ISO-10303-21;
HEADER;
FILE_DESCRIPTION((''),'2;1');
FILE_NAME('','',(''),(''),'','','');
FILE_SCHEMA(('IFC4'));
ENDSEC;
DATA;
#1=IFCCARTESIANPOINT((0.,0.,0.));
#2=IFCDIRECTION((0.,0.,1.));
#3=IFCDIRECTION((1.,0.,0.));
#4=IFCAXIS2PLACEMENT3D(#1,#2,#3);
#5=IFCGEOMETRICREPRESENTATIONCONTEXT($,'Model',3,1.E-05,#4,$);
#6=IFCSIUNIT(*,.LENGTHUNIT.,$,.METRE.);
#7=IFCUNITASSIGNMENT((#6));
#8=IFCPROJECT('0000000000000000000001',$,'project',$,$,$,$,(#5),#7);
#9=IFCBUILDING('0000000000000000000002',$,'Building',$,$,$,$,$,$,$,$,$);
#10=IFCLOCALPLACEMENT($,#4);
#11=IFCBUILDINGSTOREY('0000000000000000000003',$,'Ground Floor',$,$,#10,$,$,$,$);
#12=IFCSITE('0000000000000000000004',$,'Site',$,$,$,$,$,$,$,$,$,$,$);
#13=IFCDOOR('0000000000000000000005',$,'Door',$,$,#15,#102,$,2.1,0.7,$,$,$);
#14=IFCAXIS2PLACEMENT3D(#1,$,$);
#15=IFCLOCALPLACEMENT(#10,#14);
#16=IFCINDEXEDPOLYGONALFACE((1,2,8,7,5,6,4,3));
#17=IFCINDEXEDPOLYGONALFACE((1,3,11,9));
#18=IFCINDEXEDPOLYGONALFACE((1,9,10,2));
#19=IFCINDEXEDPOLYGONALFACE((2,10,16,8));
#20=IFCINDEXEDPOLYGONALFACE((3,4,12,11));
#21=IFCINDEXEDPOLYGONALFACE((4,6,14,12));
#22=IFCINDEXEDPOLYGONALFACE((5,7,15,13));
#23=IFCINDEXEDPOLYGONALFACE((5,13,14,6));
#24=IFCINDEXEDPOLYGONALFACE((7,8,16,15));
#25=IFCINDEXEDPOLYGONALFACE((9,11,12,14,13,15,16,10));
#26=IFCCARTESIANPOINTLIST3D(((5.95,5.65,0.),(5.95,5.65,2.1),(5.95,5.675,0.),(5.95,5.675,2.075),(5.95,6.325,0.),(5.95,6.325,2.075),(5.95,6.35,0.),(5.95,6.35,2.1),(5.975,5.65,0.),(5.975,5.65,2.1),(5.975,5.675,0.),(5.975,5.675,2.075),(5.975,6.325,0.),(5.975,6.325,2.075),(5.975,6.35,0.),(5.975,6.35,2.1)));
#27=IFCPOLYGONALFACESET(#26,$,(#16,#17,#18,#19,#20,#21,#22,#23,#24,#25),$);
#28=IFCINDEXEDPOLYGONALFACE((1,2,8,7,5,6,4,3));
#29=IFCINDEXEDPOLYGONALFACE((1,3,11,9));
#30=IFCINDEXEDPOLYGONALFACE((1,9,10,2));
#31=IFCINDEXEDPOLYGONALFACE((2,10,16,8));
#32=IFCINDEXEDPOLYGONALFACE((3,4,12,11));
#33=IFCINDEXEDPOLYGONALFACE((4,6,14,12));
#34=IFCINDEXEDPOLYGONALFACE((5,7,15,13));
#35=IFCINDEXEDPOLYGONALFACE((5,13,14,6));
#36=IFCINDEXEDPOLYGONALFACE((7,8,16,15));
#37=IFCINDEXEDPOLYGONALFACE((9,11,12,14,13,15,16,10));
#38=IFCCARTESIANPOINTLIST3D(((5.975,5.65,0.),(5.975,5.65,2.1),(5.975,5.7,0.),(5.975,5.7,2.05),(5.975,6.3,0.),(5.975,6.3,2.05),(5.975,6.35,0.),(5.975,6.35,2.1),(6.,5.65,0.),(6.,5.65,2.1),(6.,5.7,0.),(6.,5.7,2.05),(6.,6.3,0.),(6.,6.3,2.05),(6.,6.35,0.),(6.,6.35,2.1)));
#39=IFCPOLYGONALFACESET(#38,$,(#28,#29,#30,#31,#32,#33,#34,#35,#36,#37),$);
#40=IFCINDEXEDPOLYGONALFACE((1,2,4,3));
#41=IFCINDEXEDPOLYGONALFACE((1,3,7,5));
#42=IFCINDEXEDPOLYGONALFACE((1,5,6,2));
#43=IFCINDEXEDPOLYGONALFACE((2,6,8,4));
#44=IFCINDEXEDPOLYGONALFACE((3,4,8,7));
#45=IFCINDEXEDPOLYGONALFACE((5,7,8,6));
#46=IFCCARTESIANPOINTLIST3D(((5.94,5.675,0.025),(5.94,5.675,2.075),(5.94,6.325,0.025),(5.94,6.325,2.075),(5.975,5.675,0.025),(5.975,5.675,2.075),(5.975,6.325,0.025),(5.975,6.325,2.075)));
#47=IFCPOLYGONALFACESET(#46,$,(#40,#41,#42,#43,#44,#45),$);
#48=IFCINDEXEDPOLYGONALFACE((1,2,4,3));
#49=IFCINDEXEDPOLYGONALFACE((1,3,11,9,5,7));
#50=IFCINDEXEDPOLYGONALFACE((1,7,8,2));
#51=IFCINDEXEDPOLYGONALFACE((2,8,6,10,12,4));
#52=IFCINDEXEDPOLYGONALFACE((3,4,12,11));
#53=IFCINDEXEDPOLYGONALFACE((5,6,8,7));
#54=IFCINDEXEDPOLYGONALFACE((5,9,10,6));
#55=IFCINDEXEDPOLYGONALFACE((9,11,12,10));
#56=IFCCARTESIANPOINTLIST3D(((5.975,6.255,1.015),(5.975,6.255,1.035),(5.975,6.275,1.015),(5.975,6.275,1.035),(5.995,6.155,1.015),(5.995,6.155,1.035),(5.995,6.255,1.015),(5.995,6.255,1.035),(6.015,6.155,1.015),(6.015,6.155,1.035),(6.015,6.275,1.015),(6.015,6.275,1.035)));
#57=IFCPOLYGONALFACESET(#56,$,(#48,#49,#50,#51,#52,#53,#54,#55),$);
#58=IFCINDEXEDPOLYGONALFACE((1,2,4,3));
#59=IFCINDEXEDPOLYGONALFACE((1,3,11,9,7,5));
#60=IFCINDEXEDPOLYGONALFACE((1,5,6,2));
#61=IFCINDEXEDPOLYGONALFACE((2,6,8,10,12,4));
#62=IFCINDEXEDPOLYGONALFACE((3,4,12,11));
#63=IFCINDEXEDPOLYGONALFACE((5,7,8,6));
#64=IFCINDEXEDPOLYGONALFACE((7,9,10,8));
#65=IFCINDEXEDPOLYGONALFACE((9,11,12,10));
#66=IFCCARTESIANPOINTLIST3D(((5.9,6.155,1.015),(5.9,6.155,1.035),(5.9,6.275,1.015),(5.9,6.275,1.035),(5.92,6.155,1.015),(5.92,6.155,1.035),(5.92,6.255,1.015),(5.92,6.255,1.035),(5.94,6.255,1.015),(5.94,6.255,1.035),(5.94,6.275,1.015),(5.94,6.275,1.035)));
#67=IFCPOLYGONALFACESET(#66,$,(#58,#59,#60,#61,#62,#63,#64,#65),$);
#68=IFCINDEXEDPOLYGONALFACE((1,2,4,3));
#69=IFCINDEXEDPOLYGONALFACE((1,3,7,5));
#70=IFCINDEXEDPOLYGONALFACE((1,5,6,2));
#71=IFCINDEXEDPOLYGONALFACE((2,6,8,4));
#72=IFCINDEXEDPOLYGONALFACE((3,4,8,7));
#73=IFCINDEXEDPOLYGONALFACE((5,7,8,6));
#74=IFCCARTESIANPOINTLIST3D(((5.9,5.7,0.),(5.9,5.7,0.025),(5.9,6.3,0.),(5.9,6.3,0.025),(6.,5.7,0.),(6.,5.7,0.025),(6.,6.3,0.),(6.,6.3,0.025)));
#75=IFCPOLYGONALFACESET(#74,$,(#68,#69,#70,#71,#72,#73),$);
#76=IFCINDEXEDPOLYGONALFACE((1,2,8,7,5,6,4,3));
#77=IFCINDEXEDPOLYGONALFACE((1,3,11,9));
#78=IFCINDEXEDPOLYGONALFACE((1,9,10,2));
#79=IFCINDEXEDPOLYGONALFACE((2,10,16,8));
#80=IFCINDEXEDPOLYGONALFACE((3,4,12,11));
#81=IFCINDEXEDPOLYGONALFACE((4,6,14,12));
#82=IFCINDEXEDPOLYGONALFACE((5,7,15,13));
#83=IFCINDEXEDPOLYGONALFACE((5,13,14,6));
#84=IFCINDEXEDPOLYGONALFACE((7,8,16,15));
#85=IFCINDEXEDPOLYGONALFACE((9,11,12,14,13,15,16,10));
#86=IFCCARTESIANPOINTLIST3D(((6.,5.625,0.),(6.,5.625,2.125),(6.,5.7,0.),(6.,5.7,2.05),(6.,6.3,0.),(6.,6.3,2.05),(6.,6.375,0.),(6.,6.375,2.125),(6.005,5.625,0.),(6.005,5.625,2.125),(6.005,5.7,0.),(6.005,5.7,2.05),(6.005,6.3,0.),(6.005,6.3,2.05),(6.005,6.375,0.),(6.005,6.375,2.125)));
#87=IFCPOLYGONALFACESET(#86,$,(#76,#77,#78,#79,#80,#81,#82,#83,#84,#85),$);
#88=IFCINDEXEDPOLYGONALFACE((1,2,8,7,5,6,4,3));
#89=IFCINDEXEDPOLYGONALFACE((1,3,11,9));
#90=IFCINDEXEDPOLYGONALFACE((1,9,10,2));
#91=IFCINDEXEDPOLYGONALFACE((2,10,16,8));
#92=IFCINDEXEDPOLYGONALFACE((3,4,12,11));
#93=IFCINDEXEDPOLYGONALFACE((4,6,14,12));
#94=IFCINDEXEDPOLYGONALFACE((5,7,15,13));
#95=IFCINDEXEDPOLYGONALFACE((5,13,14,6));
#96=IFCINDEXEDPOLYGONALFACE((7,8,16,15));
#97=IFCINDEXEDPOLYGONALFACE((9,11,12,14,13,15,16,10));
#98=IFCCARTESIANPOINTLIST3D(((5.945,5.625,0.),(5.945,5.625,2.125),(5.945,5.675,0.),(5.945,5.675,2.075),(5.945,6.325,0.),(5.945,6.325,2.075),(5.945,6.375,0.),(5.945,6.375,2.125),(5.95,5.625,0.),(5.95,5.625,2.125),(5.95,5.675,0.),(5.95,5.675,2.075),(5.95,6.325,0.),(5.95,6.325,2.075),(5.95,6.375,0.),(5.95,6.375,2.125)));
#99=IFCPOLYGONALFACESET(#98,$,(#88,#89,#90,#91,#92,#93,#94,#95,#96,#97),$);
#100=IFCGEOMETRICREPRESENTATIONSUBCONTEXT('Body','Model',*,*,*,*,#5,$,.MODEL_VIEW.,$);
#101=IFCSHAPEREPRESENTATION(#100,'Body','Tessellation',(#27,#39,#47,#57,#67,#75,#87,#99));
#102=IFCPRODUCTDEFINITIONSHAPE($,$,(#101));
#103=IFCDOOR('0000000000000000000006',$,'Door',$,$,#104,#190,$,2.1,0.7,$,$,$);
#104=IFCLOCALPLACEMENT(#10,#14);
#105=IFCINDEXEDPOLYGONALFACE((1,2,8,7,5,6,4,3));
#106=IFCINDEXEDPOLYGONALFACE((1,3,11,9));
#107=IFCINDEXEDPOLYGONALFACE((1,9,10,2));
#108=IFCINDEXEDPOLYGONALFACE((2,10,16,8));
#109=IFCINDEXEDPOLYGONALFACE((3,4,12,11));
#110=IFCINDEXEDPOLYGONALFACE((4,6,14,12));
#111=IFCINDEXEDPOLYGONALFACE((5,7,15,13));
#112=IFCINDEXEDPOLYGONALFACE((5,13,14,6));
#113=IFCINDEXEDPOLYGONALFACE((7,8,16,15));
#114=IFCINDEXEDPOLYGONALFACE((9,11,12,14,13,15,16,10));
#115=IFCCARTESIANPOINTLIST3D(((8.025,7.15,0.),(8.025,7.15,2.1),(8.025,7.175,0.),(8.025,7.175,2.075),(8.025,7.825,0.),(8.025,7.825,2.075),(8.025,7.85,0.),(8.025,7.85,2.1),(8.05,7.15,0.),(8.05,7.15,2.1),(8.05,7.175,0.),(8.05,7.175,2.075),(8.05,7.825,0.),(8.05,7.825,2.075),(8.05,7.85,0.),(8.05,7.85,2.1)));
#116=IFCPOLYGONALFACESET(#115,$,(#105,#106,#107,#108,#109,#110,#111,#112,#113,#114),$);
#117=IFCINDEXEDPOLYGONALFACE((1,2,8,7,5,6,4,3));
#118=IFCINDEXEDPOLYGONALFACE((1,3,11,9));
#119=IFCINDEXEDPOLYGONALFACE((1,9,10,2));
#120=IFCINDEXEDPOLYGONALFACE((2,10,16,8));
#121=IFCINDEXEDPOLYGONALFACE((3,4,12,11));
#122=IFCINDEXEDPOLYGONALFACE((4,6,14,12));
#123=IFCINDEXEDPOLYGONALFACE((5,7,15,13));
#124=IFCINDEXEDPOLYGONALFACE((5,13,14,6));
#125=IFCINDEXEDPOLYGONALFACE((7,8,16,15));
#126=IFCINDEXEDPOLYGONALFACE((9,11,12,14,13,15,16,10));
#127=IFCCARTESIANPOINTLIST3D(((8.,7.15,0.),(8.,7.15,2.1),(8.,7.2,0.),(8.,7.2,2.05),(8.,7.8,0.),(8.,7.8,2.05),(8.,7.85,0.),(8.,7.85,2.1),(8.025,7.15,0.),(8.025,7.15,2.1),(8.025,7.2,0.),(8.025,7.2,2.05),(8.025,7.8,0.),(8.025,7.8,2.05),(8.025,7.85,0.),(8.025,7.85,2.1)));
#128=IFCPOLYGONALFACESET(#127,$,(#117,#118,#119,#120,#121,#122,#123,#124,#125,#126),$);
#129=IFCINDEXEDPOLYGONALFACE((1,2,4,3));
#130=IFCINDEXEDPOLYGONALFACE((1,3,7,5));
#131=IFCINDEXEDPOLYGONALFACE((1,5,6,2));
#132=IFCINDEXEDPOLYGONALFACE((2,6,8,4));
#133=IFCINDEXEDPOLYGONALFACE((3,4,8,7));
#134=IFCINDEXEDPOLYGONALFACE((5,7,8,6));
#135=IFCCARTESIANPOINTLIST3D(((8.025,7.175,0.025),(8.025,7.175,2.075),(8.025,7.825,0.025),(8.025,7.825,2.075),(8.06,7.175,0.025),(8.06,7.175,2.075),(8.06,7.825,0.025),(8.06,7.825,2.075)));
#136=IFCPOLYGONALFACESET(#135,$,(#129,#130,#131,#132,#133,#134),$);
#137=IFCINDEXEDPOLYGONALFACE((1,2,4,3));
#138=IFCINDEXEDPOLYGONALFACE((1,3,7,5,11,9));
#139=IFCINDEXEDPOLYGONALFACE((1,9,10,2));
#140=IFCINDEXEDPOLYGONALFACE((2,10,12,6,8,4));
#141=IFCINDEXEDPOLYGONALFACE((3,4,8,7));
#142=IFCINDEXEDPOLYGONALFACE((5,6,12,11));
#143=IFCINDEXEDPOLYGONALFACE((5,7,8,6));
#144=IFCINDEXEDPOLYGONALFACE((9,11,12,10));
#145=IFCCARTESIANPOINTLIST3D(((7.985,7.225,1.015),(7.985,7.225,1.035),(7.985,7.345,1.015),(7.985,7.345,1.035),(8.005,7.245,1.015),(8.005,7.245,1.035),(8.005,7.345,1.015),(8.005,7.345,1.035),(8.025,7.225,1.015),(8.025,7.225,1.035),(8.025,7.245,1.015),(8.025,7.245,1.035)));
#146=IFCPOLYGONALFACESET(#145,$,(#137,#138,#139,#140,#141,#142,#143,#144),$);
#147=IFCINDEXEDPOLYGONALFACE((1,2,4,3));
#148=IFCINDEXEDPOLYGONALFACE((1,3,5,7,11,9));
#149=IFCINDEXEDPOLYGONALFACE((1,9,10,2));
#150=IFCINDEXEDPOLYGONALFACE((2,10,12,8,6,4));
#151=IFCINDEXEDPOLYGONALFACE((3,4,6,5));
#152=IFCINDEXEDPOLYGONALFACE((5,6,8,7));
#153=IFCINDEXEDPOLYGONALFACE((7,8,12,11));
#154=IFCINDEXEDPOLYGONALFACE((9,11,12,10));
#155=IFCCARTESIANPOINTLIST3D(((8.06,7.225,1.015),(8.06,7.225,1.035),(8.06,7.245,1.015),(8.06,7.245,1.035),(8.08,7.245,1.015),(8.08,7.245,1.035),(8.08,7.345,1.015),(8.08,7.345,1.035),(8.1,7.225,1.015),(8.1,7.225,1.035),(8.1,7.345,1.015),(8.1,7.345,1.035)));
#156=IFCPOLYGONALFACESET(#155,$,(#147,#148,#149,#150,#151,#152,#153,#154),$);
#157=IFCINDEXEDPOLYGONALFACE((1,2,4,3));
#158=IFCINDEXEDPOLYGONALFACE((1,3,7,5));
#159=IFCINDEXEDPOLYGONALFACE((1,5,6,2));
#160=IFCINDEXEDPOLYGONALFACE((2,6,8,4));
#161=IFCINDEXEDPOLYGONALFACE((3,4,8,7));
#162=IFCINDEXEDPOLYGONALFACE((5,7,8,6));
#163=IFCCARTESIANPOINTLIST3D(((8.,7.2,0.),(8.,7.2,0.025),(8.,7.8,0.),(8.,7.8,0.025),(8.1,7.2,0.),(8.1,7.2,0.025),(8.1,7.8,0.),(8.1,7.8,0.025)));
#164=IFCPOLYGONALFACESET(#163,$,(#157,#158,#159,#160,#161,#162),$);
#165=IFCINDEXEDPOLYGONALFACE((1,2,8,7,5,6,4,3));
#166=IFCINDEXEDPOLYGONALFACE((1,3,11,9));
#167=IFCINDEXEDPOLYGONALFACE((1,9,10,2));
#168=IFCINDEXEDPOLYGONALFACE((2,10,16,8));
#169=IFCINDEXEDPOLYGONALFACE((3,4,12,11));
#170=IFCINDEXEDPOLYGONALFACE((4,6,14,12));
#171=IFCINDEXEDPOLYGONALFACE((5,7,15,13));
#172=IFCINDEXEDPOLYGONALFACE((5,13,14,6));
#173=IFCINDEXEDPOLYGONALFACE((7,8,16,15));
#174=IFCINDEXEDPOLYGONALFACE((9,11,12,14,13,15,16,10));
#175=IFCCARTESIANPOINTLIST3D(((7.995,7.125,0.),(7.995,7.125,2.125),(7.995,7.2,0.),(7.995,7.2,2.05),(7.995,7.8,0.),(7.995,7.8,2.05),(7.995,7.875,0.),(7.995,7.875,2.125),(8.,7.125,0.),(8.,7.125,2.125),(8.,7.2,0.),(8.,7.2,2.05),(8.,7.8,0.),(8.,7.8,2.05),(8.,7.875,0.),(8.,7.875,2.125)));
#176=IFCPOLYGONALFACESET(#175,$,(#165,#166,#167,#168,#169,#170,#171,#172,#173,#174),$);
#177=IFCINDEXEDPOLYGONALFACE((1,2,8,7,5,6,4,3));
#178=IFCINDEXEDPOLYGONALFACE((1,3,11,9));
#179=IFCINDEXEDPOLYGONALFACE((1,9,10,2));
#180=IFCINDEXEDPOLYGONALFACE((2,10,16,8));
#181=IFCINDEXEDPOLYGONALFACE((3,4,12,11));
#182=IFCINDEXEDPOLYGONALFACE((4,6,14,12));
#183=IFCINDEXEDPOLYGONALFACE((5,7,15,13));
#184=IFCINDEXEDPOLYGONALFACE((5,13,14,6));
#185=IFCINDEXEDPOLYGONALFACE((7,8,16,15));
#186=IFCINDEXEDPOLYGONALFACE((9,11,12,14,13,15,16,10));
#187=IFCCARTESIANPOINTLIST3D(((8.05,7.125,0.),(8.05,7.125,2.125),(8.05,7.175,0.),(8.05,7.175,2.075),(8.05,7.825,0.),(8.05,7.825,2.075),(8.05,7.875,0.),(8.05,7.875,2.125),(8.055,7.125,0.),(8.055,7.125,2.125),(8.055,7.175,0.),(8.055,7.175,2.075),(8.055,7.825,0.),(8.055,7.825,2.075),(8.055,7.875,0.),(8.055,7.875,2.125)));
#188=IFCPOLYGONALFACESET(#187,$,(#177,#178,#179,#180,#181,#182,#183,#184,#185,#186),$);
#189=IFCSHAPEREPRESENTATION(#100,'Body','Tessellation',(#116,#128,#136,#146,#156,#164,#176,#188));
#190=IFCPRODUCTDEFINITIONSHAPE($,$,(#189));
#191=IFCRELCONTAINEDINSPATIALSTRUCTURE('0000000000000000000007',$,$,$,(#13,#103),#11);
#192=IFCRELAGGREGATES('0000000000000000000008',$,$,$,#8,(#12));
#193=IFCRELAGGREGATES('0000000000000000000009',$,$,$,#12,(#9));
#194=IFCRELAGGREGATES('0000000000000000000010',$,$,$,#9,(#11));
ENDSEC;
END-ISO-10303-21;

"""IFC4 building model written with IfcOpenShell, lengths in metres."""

from ifc_helpers import new_model, si_unit, frame, origin_with_axes, place, context, subcontext, project, spatial, line, indexed_curve, outline, extrude, element, save


model = new_model("IFC4")

# Units and contexts
model_context = context("Model", 3, precision=1e-05, world=origin_with_axes())
body_context = subcontext(model_context, "Body", "Model", "MODEL_VIEW")
ifc_project = project(units=[si_unit("LENGTHUNIT", "METRE")], contexts=[model_context])

# Site, building, storey
site = spatial("IfcSite", under=ifc_project, Name="Site")
building = spatial("IfcBuilding", under=site, Name="Building")
storey_placement = place(None, origin_with_axes())
storey = spatial("IfcBuildingStorey", under=building, at=storey_placement, Name="Ground Floor")

# Doors
door_1_placement = place(storey_placement, frame((6.0, 5.65, 0.0), z_axis=(0.0, 0.0, 1.0), x_axis=(0.0, 1.0, 0.0)))
element("IfcDoor", 1, at=door_1_placement, inside=storey, Name="Door", OverallHeight=2.1, OverallWidth=0.7, context=body_context, shape_type="SweptSolid", body=[
    extrude(outline(indexed_curve([(0.0, 0.0), (0.0, 2.1), (0.7, 2.1), (0.7, 0.0), (0.675, 0.0), (0.675, 2.075), (0.025, 2.075), (0.025, 0.0)], segments=[line(1, 2, 3, 4, 5, 6, 7, 8, 1)])), frame((0.0, 0.025, 0.0), z_axis=(0.0, -1.0, 0.0), x_axis=(1.0, 0.0, 0.0)), (0.0, 0.0, -1.0), 0.025),
    extrude(outline(indexed_curve([(0.0, 0.0), (0.0, 2.1), (0.7, 2.1), (0.7, 0.0), (0.65, 0.0), (0.65, 2.05), (0.05, 2.05), (0.05, 0.0)], segments=[line(1, 2, 3, 4, 5, 6, 7, 8, 1)])), frame((0.0, 0.0, 0.0), z_axis=(0.0, -1.0, 0.0), x_axis=(1.0, 0.0, 0.0)), (0.0, 0.0, -1.0), 0.025),
    extrude(outline(indexed_curve([(0.0, 0.0), (0.65, 0.0), (0.65, 0.035), (0.0, 0.035)], segments=[line(1, 2, 3, 4, 1)])), frame((0.025, 0.025, 0.025), z_axis=(0.0, 0.0, 1.0), x_axis=(1.0, 0.0, 0.0)), (0.0, 0.0, 1.0), 2.05),
    extrude(outline(indexed_curve([(0.0, 0.0), (0.0, -0.04), (-0.12, -0.04), (-0.12, -0.02), (-0.02, -0.02), (-0.02, 0.0)], segments=[line(1, 2, 3, 4, 5, 6, 1)])), frame((0.625, 0.025, 1.015), z_axis=(0.0, 0.0, 1.0), x_axis=(1.0, 0.0, 0.0)), (0.0, 0.0, 1.0), 0.02),
    extrude(outline(indexed_curve([(0.0, 0.0), (0.0, 0.04), (-0.12, 0.04), (-0.12, 0.02), (-0.02, 0.02), (-0.02, 0.0)], segments=[line(1, 2, 3, 4, 5, 6, 1)])), frame((0.625, 0.06, 1.015), z_axis=(0.0, 0.0, 1.0), x_axis=(1.0, 0.0, 0.0)), (0.0, 0.0, 1.0), 0.02),
    extrude(outline(indexed_curve([(0.0, 0.0), (0.6, 0.0), (0.6, 0.1), (0.0, 0.1)], segments=[line(1, 2, 3, 4, 1)])), frame((0.05, 0.0, 0.0), z_axis=(0.0, 0.0, 1.0), x_axis=(1.0, 0.0, 0.0)), (0.0, 0.0, 1.0), 0.025),
    extrude(outline(indexed_curve([(0.0, 0.0), (0.0, 2.125), (0.75, 2.125), (0.75, 0.0), (0.675, 0.0), (0.675, 2.05), (0.075, 2.05), (0.075, 0.0)], segments=[line(1, 2, 3, 4, 5, 6, 7, 8, 1)])), frame((-0.025, -0.005, 0.0), z_axis=(0.0, -1.0, 0.0), x_axis=(1.0, 0.0, 0.0)), (0.0, 0.0, -1.0), 0.005),
    extrude(outline(indexed_curve([(0.0, 0.0), (0.0, 2.125), (0.75, 2.125), (0.75, 0.0), (0.7, 0.0), (0.7, 2.075), (0.05, 2.075), (0.05, 0.0)], segments=[line(1, 2, 3, 4, 5, 6, 7, 8, 1)])), frame((-0.025, 0.05, 0.0), z_axis=(0.0, -1.0, 0.0), x_axis=(1.0, 0.0, 0.0)), (0.0, 0.0, -1.0), 0.005),
])
door_2_placement = place(storey_placement, frame((8.0, 7.85, 0.0), z_axis=(0.0, 0.0, 1.0), x_axis=(0.0, -1.0, 0.0)))
element("IfcDoor", 2, at=door_2_placement, inside=storey, Name="Door", OverallHeight=2.1, OverallWidth=0.7, context=body_context, shape_type="SweptSolid", body=[
    extrude(outline(indexed_curve([(0.0, 0.0), (0.0, 2.1), (0.7, 2.1), (0.7, 0.0), (0.675, 0.0), (0.675, 2.075), (0.025, 2.075), (0.025, 0.0)], segments=[line(1, 2, 3, 4, 5, 6, 7, 8, 1)])), frame((0.0, 0.025, 0.0), z_axis=(0.0, -1.0, 0.0), x_axis=(1.0, 0.0, 0.0)), (0.0, 0.0, -1.0), 0.025),
    extrude(outline(indexed_curve([(0.0, 0.0), (0.0, 2.1), (0.7, 2.1), (0.7, 0.0), (0.65, 0.0), (0.65, 2.05), (0.05, 2.05), (0.05, 0.0)], segments=[line(1, 2, 3, 4, 5, 6, 7, 8, 1)])), frame((0.0, 0.0, 0.0), z_axis=(0.0, -1.0, 0.0), x_axis=(1.0, 0.0, 0.0)), (0.0, 0.0, -1.0), 0.025),
    extrude(outline(indexed_curve([(0.0, 0.0), (0.65, 0.0), (0.65, 0.035), (0.0, 0.035)], segments=[line(1, 2, 3, 4, 1)])), frame((0.025, 0.025, 0.025), z_axis=(0.0, 0.0, 1.0), x_axis=(1.0, 0.0, 0.0)), (0.0, 0.0, 1.0), 2.05),
    extrude(outline(indexed_curve([(0.0, 0.0), (0.0, -0.04), (-0.12, -0.04), (-0.12, -0.02), (-0.02, -0.02), (-0.02, 0.0)], segments=[line(1, 2, 3, 4, 5, 6, 1)])), frame((0.625, 0.025, 1.015), z_axis=(0.0, 0.0, 1.0), x_axis=(1.0, 0.0, 0.0)), (0.0, 0.0, 1.0), 0.02),
    extrude(outline(indexed_curve([(0.0, 0.0), (0.0, 0.04), (-0.12, 0.04), (-0.12, 0.02), (-0.02, 0.02), (-0.02, 0.0)], segments=[line(1, 2, 3, 4, 5, 6, 1)])), frame((0.625, 0.06, 1.015), z_axis=(0.0, 0.0, 1.0), x_axis=(1.0, 0.0, 0.0)), (0.0, 0.0, 1.0), 0.02),
    extrude(outline(indexed_curve([(0.0, 0.0), (0.6, 0.0), (0.6, 0.1), (0.0, 0.1)], segments=[line(1, 2, 3, 4, 1)])), frame((0.05, 0.0, 0.0), z_axis=(0.0, 0.0, 1.0), x_axis=(1.0, 0.0, 0.0)), (0.0, 0.0, 1.0), 0.025),
    extrude(outline(indexed_curve([(0.0, 0.0), (0.0, 2.125), (0.75, 2.125), (0.75, 0.0), (0.675, 0.0), (0.675, 2.05), (0.075, 2.05), (0.075, 0.0)], segments=[line(1, 2, 3, 4, 5, 6, 7, 8, 1)])), frame((-0.025, -0.005, 0.0), z_axis=(0.0, -1.0, 0.0), x_axis=(1.0, 0.0, 0.0)), (0.0, 0.0, -1.0), 0.005),
    extrude(outline(indexed_curve([(0.0, 0.0), (0.0, 2.125), (0.75, 2.125), (0.75, 0.0), (0.7, 0.0), (0.7, 2.075), (0.05, 2.075), (0.05, 0.0)], segments=[line(1, 2, 3, 4, 5, 6, 7, 8, 1)])), frame((-0.025, 0.05, 0.0), z_axis=(0.0, -1.0, 0.0), x_axis=(1.0, 0.0, 0.0)), (0.0, 0.0, -1.0), 0.005),
])

save(model, "model.ifc")
